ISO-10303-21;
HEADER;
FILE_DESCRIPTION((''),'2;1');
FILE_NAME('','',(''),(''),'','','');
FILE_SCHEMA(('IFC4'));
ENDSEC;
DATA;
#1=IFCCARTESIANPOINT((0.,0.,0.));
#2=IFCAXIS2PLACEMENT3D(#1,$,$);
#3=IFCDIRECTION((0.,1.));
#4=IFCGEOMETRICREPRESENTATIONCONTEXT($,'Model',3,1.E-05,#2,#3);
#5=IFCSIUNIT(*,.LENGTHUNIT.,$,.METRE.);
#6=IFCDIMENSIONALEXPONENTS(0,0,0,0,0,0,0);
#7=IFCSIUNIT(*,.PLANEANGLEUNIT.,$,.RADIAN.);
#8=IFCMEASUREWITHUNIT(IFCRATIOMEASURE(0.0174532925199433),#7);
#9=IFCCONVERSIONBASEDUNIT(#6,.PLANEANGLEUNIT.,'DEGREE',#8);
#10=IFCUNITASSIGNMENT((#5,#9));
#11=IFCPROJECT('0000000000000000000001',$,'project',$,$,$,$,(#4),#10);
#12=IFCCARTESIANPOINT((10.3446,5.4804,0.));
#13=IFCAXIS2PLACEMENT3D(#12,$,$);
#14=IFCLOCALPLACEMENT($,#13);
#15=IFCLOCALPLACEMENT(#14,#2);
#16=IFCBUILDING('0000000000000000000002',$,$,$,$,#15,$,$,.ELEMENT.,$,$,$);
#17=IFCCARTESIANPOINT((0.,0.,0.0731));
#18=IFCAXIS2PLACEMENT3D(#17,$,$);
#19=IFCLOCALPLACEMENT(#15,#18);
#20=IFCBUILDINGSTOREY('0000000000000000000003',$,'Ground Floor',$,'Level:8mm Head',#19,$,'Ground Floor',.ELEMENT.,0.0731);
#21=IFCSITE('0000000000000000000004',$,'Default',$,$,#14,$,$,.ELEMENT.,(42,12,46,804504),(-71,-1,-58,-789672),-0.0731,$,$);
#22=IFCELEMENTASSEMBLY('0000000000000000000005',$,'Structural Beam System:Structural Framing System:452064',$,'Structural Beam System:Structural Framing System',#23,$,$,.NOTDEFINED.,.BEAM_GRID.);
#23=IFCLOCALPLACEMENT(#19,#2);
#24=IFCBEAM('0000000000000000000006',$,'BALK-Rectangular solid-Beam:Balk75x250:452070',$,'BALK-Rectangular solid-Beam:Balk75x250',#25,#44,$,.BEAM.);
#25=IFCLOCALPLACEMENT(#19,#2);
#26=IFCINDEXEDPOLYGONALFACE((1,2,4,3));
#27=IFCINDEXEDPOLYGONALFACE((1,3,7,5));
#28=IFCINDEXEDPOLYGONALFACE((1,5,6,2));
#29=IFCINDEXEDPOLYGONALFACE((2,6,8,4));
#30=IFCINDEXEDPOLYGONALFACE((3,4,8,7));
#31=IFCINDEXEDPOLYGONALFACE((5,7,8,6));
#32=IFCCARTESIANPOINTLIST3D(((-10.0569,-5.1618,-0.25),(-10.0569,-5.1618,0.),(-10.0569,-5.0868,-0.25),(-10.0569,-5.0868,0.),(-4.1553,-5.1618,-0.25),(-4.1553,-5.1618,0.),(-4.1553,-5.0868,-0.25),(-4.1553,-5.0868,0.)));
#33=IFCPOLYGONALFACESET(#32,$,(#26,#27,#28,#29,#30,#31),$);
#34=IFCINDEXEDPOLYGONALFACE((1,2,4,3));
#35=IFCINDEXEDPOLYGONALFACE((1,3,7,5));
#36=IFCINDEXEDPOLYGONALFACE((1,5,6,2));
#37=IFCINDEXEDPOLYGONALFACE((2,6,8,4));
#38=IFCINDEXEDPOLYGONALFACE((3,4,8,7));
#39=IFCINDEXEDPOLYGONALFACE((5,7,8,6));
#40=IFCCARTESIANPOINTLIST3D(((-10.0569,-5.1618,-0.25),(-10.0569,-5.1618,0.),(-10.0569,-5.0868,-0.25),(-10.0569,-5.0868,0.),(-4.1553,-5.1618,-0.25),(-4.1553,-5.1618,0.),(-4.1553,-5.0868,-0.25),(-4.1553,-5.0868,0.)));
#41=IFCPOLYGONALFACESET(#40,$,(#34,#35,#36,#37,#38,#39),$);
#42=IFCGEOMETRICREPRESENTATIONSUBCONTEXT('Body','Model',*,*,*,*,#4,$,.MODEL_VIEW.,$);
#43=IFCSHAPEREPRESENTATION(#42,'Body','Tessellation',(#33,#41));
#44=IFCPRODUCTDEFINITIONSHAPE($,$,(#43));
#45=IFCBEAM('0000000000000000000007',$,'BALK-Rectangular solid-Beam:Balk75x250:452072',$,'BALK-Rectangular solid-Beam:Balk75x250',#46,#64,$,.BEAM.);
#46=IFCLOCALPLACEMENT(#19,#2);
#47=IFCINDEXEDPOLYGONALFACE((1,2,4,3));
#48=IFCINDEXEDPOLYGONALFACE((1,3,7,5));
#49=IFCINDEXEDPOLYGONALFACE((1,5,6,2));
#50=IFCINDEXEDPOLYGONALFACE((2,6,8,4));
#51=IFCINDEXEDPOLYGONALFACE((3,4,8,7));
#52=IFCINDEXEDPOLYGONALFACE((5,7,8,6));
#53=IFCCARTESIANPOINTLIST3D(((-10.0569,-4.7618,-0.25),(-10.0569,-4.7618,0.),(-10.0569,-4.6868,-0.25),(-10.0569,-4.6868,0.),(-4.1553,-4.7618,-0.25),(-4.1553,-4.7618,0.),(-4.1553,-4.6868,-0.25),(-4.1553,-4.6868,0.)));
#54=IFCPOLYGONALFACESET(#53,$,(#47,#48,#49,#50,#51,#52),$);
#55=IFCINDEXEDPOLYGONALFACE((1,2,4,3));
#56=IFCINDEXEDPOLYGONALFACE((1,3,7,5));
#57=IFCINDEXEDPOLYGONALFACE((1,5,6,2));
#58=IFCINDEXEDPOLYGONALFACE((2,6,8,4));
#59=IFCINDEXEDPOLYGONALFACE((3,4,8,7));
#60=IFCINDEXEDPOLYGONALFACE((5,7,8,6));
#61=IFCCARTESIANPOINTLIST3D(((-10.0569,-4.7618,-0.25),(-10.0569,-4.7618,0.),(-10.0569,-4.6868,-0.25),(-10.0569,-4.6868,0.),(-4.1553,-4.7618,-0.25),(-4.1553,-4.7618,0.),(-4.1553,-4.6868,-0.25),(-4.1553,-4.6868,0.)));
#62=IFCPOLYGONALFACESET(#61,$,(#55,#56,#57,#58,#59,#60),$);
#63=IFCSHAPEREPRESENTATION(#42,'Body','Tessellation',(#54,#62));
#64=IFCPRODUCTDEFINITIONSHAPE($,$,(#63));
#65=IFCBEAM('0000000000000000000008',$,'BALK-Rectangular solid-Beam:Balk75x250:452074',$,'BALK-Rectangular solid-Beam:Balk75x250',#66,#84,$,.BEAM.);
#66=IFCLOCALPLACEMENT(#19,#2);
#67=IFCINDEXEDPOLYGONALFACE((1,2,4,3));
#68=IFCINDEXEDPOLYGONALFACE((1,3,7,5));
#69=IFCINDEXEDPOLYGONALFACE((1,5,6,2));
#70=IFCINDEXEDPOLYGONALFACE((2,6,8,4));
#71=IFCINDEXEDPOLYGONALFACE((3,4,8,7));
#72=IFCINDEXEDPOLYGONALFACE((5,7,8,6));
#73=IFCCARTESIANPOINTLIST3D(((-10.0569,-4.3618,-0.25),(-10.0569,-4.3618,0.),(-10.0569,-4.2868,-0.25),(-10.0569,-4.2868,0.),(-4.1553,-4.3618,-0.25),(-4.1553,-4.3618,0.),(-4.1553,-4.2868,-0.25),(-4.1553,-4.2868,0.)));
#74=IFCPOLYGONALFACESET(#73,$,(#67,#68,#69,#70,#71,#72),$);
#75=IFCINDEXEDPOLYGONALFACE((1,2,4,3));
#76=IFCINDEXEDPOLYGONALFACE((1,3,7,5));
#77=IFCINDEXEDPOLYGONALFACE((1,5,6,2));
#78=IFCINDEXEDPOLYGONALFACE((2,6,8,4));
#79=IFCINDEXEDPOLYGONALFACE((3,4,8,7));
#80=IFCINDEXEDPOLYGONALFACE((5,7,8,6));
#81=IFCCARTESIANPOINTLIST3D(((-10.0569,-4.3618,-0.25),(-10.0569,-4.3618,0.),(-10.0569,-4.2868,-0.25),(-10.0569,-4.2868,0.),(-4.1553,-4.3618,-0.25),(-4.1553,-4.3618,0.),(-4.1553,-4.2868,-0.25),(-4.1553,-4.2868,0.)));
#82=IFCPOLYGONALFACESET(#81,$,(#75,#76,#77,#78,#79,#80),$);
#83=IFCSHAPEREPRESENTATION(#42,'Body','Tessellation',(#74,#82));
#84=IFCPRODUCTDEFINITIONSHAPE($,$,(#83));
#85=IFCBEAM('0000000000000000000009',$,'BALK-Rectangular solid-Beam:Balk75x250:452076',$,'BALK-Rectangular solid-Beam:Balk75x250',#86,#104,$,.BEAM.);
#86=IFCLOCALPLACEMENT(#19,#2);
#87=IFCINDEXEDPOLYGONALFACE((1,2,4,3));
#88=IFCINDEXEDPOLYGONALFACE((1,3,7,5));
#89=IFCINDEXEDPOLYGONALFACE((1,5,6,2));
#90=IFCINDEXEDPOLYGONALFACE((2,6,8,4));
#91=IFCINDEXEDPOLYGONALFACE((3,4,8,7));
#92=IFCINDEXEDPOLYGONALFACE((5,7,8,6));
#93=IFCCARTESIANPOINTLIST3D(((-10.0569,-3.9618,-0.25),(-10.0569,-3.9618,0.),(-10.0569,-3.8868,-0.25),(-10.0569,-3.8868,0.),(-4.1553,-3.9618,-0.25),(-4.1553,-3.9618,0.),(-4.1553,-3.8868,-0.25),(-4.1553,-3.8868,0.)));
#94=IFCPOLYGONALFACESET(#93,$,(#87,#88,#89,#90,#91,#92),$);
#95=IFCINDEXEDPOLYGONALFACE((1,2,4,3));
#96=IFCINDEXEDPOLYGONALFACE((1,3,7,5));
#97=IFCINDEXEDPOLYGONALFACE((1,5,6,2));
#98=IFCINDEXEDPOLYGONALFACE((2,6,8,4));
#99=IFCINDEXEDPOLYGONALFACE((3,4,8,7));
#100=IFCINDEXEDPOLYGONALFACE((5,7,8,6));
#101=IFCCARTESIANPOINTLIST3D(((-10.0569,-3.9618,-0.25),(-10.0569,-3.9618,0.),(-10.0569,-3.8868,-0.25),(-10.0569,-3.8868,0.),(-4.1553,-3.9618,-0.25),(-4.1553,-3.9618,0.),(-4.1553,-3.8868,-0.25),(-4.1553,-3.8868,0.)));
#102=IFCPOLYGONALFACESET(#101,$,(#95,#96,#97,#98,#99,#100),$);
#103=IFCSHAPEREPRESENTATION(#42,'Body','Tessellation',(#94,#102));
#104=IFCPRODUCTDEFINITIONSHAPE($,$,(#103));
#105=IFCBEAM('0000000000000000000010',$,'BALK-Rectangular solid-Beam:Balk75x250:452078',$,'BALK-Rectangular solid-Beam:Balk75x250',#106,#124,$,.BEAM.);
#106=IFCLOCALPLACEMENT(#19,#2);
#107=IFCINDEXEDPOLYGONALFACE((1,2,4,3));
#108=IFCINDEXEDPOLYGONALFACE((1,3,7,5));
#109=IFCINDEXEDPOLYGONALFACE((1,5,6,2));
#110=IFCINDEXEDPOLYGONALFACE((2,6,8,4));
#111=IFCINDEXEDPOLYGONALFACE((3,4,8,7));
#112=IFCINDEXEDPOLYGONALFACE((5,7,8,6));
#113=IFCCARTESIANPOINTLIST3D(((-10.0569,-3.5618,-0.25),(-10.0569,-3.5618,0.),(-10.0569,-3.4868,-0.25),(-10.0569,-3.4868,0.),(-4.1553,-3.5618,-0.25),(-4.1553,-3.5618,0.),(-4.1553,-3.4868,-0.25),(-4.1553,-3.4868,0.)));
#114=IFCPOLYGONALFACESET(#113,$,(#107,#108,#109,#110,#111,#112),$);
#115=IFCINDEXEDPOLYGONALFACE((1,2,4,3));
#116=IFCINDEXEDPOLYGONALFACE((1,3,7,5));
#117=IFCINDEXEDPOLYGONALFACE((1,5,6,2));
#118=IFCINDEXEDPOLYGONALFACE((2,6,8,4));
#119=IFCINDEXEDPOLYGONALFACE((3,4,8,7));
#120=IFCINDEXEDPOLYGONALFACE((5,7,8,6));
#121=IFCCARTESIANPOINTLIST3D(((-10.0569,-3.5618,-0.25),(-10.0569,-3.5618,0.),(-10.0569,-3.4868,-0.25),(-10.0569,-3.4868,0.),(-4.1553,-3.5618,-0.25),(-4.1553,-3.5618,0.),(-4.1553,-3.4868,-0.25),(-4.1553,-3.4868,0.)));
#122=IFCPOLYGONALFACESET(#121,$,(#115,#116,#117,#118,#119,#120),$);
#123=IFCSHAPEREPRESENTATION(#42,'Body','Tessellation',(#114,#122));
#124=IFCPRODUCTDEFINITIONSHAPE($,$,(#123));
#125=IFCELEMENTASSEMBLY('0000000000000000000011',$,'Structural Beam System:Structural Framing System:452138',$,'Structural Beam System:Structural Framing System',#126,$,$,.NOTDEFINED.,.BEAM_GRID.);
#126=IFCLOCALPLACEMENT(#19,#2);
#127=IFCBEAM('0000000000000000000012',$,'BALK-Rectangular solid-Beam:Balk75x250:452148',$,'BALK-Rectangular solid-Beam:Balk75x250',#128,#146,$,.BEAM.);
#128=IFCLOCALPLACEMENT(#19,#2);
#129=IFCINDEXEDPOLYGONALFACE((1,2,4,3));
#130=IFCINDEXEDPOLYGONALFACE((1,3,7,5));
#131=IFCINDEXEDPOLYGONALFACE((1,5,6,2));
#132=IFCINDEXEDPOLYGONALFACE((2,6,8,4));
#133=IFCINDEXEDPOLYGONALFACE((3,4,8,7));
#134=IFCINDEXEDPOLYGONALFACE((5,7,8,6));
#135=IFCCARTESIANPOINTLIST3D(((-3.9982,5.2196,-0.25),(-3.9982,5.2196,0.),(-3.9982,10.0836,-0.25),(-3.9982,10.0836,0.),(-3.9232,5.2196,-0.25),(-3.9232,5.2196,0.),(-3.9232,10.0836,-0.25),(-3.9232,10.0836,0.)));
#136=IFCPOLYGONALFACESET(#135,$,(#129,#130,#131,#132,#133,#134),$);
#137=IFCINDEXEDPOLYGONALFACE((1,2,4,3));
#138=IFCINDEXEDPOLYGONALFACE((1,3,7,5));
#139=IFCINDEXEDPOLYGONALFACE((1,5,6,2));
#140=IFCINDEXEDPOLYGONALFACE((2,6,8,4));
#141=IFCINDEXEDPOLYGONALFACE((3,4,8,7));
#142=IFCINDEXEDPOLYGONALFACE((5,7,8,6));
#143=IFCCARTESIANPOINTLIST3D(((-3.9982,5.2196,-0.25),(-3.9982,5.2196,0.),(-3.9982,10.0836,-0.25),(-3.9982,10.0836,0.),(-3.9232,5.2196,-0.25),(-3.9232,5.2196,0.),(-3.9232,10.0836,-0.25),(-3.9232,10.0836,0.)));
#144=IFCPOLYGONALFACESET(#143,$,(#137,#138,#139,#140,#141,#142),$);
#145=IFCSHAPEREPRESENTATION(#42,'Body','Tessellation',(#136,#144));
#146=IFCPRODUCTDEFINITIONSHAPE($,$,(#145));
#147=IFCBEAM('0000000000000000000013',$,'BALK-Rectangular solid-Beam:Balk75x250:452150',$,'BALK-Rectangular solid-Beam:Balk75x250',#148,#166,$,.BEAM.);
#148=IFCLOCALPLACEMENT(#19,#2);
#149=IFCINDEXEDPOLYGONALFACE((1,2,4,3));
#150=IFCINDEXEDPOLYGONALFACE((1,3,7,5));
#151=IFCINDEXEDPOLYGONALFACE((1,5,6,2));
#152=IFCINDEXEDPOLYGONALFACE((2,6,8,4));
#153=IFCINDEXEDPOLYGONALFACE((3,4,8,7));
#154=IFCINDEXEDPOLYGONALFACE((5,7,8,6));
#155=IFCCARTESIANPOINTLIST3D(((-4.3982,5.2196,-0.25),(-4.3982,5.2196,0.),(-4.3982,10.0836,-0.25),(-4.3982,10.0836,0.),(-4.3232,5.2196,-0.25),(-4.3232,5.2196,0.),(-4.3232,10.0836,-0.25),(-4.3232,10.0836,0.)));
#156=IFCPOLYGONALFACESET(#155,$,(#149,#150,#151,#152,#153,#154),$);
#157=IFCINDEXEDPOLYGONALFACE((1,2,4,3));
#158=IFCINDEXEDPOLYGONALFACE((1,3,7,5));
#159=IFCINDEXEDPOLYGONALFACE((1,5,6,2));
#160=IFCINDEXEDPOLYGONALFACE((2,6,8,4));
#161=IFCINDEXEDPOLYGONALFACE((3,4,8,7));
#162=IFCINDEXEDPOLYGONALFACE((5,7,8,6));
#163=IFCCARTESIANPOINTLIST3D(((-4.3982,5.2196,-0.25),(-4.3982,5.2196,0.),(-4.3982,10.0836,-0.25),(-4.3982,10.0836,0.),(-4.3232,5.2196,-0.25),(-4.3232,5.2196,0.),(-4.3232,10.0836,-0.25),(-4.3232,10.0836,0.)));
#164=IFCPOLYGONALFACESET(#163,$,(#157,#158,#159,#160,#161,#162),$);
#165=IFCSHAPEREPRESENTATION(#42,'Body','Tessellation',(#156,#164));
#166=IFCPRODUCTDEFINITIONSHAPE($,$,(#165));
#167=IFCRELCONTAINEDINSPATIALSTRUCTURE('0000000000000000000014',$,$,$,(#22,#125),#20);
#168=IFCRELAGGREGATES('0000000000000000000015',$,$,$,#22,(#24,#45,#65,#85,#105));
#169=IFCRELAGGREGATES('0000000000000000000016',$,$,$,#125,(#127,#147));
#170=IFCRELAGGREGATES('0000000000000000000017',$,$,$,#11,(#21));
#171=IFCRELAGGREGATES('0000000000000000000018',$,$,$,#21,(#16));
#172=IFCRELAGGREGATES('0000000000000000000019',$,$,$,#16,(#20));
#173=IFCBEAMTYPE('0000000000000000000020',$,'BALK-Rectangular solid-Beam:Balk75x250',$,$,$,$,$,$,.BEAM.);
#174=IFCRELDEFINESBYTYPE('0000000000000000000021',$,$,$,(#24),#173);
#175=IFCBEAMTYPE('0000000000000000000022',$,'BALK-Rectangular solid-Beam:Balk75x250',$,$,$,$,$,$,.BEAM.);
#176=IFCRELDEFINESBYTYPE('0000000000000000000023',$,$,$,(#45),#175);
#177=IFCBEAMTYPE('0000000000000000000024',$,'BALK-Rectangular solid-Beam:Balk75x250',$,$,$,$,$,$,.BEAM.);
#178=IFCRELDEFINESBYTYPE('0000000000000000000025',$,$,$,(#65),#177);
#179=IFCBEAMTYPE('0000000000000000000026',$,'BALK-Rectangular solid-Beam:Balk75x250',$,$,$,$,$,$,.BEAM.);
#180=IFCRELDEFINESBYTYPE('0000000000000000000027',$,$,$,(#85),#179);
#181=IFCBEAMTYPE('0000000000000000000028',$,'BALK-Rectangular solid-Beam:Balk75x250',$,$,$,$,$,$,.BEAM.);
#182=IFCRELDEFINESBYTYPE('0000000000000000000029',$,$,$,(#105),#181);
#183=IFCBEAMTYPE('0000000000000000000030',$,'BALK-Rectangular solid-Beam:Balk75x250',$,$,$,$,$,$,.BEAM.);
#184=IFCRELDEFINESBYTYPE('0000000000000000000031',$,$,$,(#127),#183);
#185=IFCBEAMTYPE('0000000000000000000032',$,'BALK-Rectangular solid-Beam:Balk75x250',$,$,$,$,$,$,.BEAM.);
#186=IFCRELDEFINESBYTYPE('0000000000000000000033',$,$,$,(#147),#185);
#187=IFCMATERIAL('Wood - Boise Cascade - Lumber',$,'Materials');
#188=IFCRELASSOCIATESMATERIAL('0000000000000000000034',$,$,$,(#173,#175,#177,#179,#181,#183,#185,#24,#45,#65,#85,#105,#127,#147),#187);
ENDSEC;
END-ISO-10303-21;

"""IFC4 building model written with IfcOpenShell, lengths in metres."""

from ifc_helpers import new_model, entity, si_unit, converted_unit, direction, frame, frame_2d, origin, place, context, subcontext, project, spatial, rectangle, extrude, source, transform, mapped, material, material_profile, profile_set, profile_usage, type_object, type_shapes, element, aggregate, save


model = new_model("IFC4")

# Units and contexts
model_context = context("Model", 3, precision=1e-05, world=origin(), true_north=direction((0.0, 1.0)))
body_context = subcontext(model_context, "Body", "Model", "MODEL_VIEW")
ifc_project = project(units=[si_unit("LENGTHUNIT", "METRE"), converted_unit("PLANEANGLEUNIT", "DEGREE", entity("IfcRatioMeasure", 0.0174532925199433), si_unit("PLANEANGLEUNIT", "RADIAN"), dimensions=[0, 0, 0, 0, 0, 0, 0])], contexts=[model_context])

# Site, building, storey
site_placement = place(None, frame((10.3446, 5.4804, 0.0)))
site = spatial("IfcSite", under=ifc_project, at=site_placement, Name="Default", CompositionType="ELEMENT", RefLatitude=(42, 12, 46, 804504), RefLongitude=(-71, -1, -58, -789672), RefElevation=-0.0731)
building_placement = place(site_placement, origin())
building = spatial("IfcBuilding", under=site, at=building_placement, CompositionType="ELEMENT")
storey_placement = place(building_placement, frame((0.0, 0.0, 0.0731)))
storey = spatial("IfcBuildingStorey", under=building, at=storey_placement, Name="Ground Floor", ObjectType="Level:8mm Head", LongName="Ground Floor", CompositionType="ELEMENT", Elevation=0.0731)

# Element assemblies, beams
assembly_1_placement = place(storey_placement, origin())
assembly_1 = element("IfcElementAssembly", 1, at=assembly_1_placement, inside=storey, Name="Structural Beam System:Structural Framing System:452064", ObjectType="Structural Beam System:Structural Framing System", AssemblyPlace="NOTDEFINED", PredefinedType="BEAM_GRID")
ifc_material_1 = material(Name="Wood - Boise Cascade - Lumber", Category="Materials")
ifc_material_profile = material_profile(ifc_material_1, rectangle(XDim=0.25, YDim=0.075, at=frame_2d((0.0, 0.0), x_axis=(1.0, 0.0))), Name="Balk75x250")
ifc_profile_set = profile_set([ifc_material_profile], Name="Balk75x250")
ifc_profile_usage_1 = profile_usage(ifc_profile_set, cardinal=8)
beam_type_1 = type_object("IfcBeamType", Name="BALK-Rectangular solid-Beam:Balk75x250", PredefinedType="BEAM", material=ifc_profile_set)
shared_shape_1 = source(origin(), body_context, "Body", "SweptSolid", [
    extrude(rectangle(XDim=0.25, YDim=0.075, at=frame_2d((0.0, 0.0), x_axis=(1.0, 0.0))), frame((-10.0569, -5.1243, -0.0519), z_axis=(1.0, 0.0, 0.0), x_axis=(0.0, 0.0, -1.0)), (0.0, 0.0, 1.0), 5.9016),
    extrude(rectangle(XDim=0.25, YDim=0.075, at=frame_2d((0.0, 0.0), x_axis=(1.0, 0.0))), frame((-10.0569, -5.1243, -0.0519), z_axis=(1.0, 0.0, 0.0), x_axis=(0.0, 0.0, -1.0)), (0.0, 0.0, 1.0), 5.9016),
])
type_shapes(beam_type_1, [shared_shape_1])
beam_1_placement = place(assembly_1_placement, frame((0.0, 0.0, -0.0731)))
beam_1 = element("IfcBeam", 2, at=beam_1_placement, type_object=beam_type_1, material=ifc_profile_usage_1, Name="BALK-Rectangular solid-Beam:Balk75x250:452070", ObjectType="BALK-Rectangular solid-Beam:Balk75x250", PredefinedType="BEAM", context=body_context, shape_type="MappedRepresentation", body=[
    mapped(shared_shape_1, transform((0.0, 0.0, 0.0), scale=1.0)),
])
ifc_profile_usage_2 = profile_usage(ifc_profile_set, cardinal=8)
beam_type_2 = type_object("IfcBeamType", Name="BALK-Rectangular solid-Beam:Balk75x250", PredefinedType="BEAM", material=ifc_profile_set)
shared_shape_2 = source(origin(), body_context, "Body", "SweptSolid", [
    extrude(rectangle(XDim=0.25, YDim=0.075, at=frame_2d((0.0, 0.0), x_axis=(1.0, 0.0))), frame((-10.0569, -4.7243, -0.0519), z_axis=(1.0, 0.0, 0.0), x_axis=(0.0, 0.0, -1.0)), (0.0, 0.0, 1.0), 5.9016),
    extrude(rectangle(XDim=0.25, YDim=0.075, at=frame_2d((0.0, 0.0), x_axis=(1.0, 0.0))), frame((-10.0569, -4.7243, -0.0519), z_axis=(1.0, 0.0, 0.0), x_axis=(0.0, 0.0, -1.0)), (0.0, 0.0, 1.0), 5.9016),
])
type_shapes(beam_type_2, [shared_shape_2])
beam_2_placement = place(assembly_1_placement, frame((0.0, 0.0, -0.0731)))
beam_2 = element("IfcBeam", 3, at=beam_2_placement, type_object=beam_type_2, material=ifc_profile_usage_2, Name="BALK-Rectangular solid-Beam:Balk75x250:452072", ObjectType="BALK-Rectangular solid-Beam:Balk75x250", PredefinedType="BEAM", context=body_context, shape_type="MappedRepresentation", body=[
    mapped(shared_shape_2, transform((0.0, 0.0, 0.0), scale=1.0)),
])
ifc_profile_usage_3 = profile_usage(ifc_profile_set, cardinal=8)
beam_type_3 = type_object("IfcBeamType", Name="BALK-Rectangular solid-Beam:Balk75x250", PredefinedType="BEAM", material=ifc_profile_set)
shared_shape_3 = source(origin(), body_context, "Body", "SweptSolid", [
    extrude(rectangle(XDim=0.25, YDim=0.075, at=frame_2d((0.0, 0.0), x_axis=(1.0, 0.0))), frame((-10.0569, -4.3243, -0.0519), z_axis=(1.0, 0.0, 0.0), x_axis=(0.0, 0.0, -1.0)), (0.0, 0.0, 1.0), 5.9016),
    extrude(rectangle(XDim=0.25, YDim=0.075, at=frame_2d((0.0, 0.0), x_axis=(1.0, 0.0))), frame((-10.0569, -4.3243, -0.0519), z_axis=(1.0, 0.0, 0.0), x_axis=(0.0, 0.0, -1.0)), (0.0, 0.0, 1.0), 5.9016),
])
type_shapes(beam_type_3, [shared_shape_3])
beam_3_placement = place(assembly_1_placement, frame((0.0, 0.0, -0.0731)))
beam_3 = element("IfcBeam", 4, at=beam_3_placement, type_object=beam_type_3, material=ifc_profile_usage_3, Name="BALK-Rectangular solid-Beam:Balk75x250:452074", ObjectType="BALK-Rectangular solid-Beam:Balk75x250", PredefinedType="BEAM", context=body_context, shape_type="MappedRepresentation", body=[
    mapped(shared_shape_3, transform((0.0, 0.0, 0.0), scale=1.0)),
])
ifc_profile_usage_4 = profile_usage(ifc_profile_set, cardinal=8)
beam_type_4 = type_object("IfcBeamType", Name="BALK-Rectangular solid-Beam:Balk75x250", PredefinedType="BEAM", material=ifc_profile_set)
shared_shape_4 = source(origin(), body_context, "Body", "SweptSolid", [
    extrude(rectangle(XDim=0.25, YDim=0.075, at=frame_2d((0.0, 0.0), x_axis=(1.0, 0.0))), frame((-10.0569, -3.9243, -0.0519), z_axis=(1.0, 0.0, 0.0), x_axis=(0.0, 0.0, -1.0)), (0.0, 0.0, 1.0), 5.9016),
    extrude(rectangle(XDim=0.25, YDim=0.075, at=frame_2d((0.0, 0.0), x_axis=(1.0, 0.0))), frame((-10.0569, -3.9243, -0.0519), z_axis=(1.0, 0.0, 0.0), x_axis=(0.0, 0.0, -1.0)), (0.0, 0.0, 1.0), 5.9016),
])
type_shapes(beam_type_4, [shared_shape_4])
beam_4_placement = place(assembly_1_placement, frame((0.0, 0.0, -0.0731)))
beam_4 = element("IfcBeam", 5, at=beam_4_placement, type_object=beam_type_4, material=ifc_profile_usage_4, Name="BALK-Rectangular solid-Beam:Balk75x250:452076", ObjectType="BALK-Rectangular solid-Beam:Balk75x250", PredefinedType="BEAM", context=body_context, shape_type="MappedRepresentation", body=[
    mapped(shared_shape_4, transform((0.0, 0.0, 0.0), scale=1.0)),
])
ifc_profile_usage_5 = profile_usage(ifc_profile_set, cardinal=8)
beam_type_5 = type_object("IfcBeamType", Name="BALK-Rectangular solid-Beam:Balk75x250", PredefinedType="BEAM", material=ifc_profile_set)
shared_shape_5 = source(origin(), body_context, "Body", "SweptSolid", [
    extrude(rectangle(XDim=0.25, YDim=0.075, at=frame_2d((0.0, 0.0), x_axis=(1.0, 0.0))), frame((-10.0569, -3.5243, -0.0519), z_axis=(1.0, 0.0, 0.0), x_axis=(0.0, 0.0, -1.0)), (0.0, 0.0, 1.0), 5.9016),
    extrude(rectangle(XDim=0.25, YDim=0.075, at=frame_2d((0.0, 0.0), x_axis=(1.0, 0.0))), frame((-10.0569, -3.5243, -0.0519), z_axis=(1.0, 0.0, 0.0), x_axis=(0.0, 0.0, -1.0)), (0.0, 0.0, 1.0), 5.9016),
])
type_shapes(beam_type_5, [shared_shape_5])
beam_5_placement = place(assembly_1_placement, frame((0.0, 0.0, -0.0731)))
beam_5 = element("IfcBeam", 6, at=beam_5_placement, type_object=beam_type_5, material=ifc_profile_usage_5, Name="BALK-Rectangular solid-Beam:Balk75x250:452078", ObjectType="BALK-Rectangular solid-Beam:Balk75x250", PredefinedType="BEAM", context=body_context, shape_type="MappedRepresentation", body=[
    mapped(shared_shape_5, transform((0.0, 0.0, 0.0), scale=1.0)),
])
aggregate(assembly_1, [beam_1, beam_2, beam_3, beam_4, beam_5])
assembly_2_placement = place(storey_placement, origin())
assembly_2 = element("IfcElementAssembly", 7, at=assembly_2_placement, inside=storey, Name="Structural Beam System:Structural Framing System:452138", ObjectType="Structural Beam System:Structural Framing System", AssemblyPlace="NOTDEFINED", PredefinedType="BEAM_GRID")
ifc_profile_usage_6 = profile_usage(ifc_profile_set, cardinal=8)
beam_type_6 = type_object("IfcBeamType", Name="BALK-Rectangular solid-Beam:Balk75x250", PredefinedType="BEAM", material=ifc_profile_set)
shared_shape_6 = source(origin(), body_context, "Body", "SweptSolid", [
    extrude(rectangle(XDim=0.25, YDim=0.075, at=frame_2d((0.0, 0.0), x_axis=(0.0, 1.0))), frame((-3.9607, 10.0836, -0.0519), z_axis=(0.0, -1.0, 0.0), x_axis=(-1.0, 0.0, 0.0)), (0.0, 0.0, 1.0), 4.864),
    extrude(rectangle(XDim=0.25, YDim=0.075, at=frame_2d((0.0, 0.0), x_axis=(0.0, 1.0))), frame((-3.9607, 10.0836, -0.0519), z_axis=(0.0, -1.0, 0.0), x_axis=(-1.0, 0.0, 0.0)), (0.0, 0.0, 1.0), 4.864),
])
type_shapes(beam_type_6, [shared_shape_6])
beam_6_placement = place(assembly_2_placement, frame((0.0, 0.0, -0.0731)))
beam_6 = element("IfcBeam", 8, at=beam_6_placement, type_object=beam_type_6, material=ifc_profile_usage_6, Name="BALK-Rectangular solid-Beam:Balk75x250:452148", ObjectType="BALK-Rectangular solid-Beam:Balk75x250", PredefinedType="BEAM", context=body_context, shape_type="MappedRepresentation", body=[
    mapped(shared_shape_6, transform((0.0, 0.0, 0.0), scale=1.0)),
])
ifc_profile_usage_7 = profile_usage(ifc_profile_set, cardinal=8)
beam_type_7 = type_object("IfcBeamType", Name="BALK-Rectangular solid-Beam:Balk75x250", PredefinedType="BEAM", material=ifc_profile_set)
shared_shape_7 = source(origin(), body_context, "Body", "SweptSolid", [
    extrude(rectangle(XDim=0.25, YDim=0.075, at=frame_2d((0.0, 0.0), x_axis=(0.0, 1.0))), frame((-4.3607, 10.0836, -0.0519), z_axis=(0.0, -1.0, 0.0), x_axis=(-1.0, 0.0, 0.0)), (0.0, 0.0, 1.0), 4.864),
    extrude(rectangle(XDim=0.25, YDim=0.075, at=frame_2d((0.0, 0.0), x_axis=(0.0, 1.0))), frame((-4.3607, 10.0836, -0.0519), z_axis=(0.0, -1.0, 0.0), x_axis=(-1.0, 0.0, 0.0)), (0.0, 0.0, 1.0), 4.864),
])
type_shapes(beam_type_7, [shared_shape_7])
beam_7_placement = place(assembly_2_placement, frame((0.0, 0.0, -0.0731)))
beam_7 = element("IfcBeam", 9, at=beam_7_placement, type_object=beam_type_7, material=ifc_profile_usage_7, Name="BALK-Rectangular solid-Beam:Balk75x250:452150", ObjectType="BALK-Rectangular solid-Beam:Balk75x250", PredefinedType="BEAM", context=body_context, shape_type="MappedRepresentation", body=[
    mapped(shared_shape_7, transform((0.0, 0.0, 0.0), scale=1.0)),
])
aggregate(assembly_2, [beam_6, beam_7])

save(model, "model.ifc")
